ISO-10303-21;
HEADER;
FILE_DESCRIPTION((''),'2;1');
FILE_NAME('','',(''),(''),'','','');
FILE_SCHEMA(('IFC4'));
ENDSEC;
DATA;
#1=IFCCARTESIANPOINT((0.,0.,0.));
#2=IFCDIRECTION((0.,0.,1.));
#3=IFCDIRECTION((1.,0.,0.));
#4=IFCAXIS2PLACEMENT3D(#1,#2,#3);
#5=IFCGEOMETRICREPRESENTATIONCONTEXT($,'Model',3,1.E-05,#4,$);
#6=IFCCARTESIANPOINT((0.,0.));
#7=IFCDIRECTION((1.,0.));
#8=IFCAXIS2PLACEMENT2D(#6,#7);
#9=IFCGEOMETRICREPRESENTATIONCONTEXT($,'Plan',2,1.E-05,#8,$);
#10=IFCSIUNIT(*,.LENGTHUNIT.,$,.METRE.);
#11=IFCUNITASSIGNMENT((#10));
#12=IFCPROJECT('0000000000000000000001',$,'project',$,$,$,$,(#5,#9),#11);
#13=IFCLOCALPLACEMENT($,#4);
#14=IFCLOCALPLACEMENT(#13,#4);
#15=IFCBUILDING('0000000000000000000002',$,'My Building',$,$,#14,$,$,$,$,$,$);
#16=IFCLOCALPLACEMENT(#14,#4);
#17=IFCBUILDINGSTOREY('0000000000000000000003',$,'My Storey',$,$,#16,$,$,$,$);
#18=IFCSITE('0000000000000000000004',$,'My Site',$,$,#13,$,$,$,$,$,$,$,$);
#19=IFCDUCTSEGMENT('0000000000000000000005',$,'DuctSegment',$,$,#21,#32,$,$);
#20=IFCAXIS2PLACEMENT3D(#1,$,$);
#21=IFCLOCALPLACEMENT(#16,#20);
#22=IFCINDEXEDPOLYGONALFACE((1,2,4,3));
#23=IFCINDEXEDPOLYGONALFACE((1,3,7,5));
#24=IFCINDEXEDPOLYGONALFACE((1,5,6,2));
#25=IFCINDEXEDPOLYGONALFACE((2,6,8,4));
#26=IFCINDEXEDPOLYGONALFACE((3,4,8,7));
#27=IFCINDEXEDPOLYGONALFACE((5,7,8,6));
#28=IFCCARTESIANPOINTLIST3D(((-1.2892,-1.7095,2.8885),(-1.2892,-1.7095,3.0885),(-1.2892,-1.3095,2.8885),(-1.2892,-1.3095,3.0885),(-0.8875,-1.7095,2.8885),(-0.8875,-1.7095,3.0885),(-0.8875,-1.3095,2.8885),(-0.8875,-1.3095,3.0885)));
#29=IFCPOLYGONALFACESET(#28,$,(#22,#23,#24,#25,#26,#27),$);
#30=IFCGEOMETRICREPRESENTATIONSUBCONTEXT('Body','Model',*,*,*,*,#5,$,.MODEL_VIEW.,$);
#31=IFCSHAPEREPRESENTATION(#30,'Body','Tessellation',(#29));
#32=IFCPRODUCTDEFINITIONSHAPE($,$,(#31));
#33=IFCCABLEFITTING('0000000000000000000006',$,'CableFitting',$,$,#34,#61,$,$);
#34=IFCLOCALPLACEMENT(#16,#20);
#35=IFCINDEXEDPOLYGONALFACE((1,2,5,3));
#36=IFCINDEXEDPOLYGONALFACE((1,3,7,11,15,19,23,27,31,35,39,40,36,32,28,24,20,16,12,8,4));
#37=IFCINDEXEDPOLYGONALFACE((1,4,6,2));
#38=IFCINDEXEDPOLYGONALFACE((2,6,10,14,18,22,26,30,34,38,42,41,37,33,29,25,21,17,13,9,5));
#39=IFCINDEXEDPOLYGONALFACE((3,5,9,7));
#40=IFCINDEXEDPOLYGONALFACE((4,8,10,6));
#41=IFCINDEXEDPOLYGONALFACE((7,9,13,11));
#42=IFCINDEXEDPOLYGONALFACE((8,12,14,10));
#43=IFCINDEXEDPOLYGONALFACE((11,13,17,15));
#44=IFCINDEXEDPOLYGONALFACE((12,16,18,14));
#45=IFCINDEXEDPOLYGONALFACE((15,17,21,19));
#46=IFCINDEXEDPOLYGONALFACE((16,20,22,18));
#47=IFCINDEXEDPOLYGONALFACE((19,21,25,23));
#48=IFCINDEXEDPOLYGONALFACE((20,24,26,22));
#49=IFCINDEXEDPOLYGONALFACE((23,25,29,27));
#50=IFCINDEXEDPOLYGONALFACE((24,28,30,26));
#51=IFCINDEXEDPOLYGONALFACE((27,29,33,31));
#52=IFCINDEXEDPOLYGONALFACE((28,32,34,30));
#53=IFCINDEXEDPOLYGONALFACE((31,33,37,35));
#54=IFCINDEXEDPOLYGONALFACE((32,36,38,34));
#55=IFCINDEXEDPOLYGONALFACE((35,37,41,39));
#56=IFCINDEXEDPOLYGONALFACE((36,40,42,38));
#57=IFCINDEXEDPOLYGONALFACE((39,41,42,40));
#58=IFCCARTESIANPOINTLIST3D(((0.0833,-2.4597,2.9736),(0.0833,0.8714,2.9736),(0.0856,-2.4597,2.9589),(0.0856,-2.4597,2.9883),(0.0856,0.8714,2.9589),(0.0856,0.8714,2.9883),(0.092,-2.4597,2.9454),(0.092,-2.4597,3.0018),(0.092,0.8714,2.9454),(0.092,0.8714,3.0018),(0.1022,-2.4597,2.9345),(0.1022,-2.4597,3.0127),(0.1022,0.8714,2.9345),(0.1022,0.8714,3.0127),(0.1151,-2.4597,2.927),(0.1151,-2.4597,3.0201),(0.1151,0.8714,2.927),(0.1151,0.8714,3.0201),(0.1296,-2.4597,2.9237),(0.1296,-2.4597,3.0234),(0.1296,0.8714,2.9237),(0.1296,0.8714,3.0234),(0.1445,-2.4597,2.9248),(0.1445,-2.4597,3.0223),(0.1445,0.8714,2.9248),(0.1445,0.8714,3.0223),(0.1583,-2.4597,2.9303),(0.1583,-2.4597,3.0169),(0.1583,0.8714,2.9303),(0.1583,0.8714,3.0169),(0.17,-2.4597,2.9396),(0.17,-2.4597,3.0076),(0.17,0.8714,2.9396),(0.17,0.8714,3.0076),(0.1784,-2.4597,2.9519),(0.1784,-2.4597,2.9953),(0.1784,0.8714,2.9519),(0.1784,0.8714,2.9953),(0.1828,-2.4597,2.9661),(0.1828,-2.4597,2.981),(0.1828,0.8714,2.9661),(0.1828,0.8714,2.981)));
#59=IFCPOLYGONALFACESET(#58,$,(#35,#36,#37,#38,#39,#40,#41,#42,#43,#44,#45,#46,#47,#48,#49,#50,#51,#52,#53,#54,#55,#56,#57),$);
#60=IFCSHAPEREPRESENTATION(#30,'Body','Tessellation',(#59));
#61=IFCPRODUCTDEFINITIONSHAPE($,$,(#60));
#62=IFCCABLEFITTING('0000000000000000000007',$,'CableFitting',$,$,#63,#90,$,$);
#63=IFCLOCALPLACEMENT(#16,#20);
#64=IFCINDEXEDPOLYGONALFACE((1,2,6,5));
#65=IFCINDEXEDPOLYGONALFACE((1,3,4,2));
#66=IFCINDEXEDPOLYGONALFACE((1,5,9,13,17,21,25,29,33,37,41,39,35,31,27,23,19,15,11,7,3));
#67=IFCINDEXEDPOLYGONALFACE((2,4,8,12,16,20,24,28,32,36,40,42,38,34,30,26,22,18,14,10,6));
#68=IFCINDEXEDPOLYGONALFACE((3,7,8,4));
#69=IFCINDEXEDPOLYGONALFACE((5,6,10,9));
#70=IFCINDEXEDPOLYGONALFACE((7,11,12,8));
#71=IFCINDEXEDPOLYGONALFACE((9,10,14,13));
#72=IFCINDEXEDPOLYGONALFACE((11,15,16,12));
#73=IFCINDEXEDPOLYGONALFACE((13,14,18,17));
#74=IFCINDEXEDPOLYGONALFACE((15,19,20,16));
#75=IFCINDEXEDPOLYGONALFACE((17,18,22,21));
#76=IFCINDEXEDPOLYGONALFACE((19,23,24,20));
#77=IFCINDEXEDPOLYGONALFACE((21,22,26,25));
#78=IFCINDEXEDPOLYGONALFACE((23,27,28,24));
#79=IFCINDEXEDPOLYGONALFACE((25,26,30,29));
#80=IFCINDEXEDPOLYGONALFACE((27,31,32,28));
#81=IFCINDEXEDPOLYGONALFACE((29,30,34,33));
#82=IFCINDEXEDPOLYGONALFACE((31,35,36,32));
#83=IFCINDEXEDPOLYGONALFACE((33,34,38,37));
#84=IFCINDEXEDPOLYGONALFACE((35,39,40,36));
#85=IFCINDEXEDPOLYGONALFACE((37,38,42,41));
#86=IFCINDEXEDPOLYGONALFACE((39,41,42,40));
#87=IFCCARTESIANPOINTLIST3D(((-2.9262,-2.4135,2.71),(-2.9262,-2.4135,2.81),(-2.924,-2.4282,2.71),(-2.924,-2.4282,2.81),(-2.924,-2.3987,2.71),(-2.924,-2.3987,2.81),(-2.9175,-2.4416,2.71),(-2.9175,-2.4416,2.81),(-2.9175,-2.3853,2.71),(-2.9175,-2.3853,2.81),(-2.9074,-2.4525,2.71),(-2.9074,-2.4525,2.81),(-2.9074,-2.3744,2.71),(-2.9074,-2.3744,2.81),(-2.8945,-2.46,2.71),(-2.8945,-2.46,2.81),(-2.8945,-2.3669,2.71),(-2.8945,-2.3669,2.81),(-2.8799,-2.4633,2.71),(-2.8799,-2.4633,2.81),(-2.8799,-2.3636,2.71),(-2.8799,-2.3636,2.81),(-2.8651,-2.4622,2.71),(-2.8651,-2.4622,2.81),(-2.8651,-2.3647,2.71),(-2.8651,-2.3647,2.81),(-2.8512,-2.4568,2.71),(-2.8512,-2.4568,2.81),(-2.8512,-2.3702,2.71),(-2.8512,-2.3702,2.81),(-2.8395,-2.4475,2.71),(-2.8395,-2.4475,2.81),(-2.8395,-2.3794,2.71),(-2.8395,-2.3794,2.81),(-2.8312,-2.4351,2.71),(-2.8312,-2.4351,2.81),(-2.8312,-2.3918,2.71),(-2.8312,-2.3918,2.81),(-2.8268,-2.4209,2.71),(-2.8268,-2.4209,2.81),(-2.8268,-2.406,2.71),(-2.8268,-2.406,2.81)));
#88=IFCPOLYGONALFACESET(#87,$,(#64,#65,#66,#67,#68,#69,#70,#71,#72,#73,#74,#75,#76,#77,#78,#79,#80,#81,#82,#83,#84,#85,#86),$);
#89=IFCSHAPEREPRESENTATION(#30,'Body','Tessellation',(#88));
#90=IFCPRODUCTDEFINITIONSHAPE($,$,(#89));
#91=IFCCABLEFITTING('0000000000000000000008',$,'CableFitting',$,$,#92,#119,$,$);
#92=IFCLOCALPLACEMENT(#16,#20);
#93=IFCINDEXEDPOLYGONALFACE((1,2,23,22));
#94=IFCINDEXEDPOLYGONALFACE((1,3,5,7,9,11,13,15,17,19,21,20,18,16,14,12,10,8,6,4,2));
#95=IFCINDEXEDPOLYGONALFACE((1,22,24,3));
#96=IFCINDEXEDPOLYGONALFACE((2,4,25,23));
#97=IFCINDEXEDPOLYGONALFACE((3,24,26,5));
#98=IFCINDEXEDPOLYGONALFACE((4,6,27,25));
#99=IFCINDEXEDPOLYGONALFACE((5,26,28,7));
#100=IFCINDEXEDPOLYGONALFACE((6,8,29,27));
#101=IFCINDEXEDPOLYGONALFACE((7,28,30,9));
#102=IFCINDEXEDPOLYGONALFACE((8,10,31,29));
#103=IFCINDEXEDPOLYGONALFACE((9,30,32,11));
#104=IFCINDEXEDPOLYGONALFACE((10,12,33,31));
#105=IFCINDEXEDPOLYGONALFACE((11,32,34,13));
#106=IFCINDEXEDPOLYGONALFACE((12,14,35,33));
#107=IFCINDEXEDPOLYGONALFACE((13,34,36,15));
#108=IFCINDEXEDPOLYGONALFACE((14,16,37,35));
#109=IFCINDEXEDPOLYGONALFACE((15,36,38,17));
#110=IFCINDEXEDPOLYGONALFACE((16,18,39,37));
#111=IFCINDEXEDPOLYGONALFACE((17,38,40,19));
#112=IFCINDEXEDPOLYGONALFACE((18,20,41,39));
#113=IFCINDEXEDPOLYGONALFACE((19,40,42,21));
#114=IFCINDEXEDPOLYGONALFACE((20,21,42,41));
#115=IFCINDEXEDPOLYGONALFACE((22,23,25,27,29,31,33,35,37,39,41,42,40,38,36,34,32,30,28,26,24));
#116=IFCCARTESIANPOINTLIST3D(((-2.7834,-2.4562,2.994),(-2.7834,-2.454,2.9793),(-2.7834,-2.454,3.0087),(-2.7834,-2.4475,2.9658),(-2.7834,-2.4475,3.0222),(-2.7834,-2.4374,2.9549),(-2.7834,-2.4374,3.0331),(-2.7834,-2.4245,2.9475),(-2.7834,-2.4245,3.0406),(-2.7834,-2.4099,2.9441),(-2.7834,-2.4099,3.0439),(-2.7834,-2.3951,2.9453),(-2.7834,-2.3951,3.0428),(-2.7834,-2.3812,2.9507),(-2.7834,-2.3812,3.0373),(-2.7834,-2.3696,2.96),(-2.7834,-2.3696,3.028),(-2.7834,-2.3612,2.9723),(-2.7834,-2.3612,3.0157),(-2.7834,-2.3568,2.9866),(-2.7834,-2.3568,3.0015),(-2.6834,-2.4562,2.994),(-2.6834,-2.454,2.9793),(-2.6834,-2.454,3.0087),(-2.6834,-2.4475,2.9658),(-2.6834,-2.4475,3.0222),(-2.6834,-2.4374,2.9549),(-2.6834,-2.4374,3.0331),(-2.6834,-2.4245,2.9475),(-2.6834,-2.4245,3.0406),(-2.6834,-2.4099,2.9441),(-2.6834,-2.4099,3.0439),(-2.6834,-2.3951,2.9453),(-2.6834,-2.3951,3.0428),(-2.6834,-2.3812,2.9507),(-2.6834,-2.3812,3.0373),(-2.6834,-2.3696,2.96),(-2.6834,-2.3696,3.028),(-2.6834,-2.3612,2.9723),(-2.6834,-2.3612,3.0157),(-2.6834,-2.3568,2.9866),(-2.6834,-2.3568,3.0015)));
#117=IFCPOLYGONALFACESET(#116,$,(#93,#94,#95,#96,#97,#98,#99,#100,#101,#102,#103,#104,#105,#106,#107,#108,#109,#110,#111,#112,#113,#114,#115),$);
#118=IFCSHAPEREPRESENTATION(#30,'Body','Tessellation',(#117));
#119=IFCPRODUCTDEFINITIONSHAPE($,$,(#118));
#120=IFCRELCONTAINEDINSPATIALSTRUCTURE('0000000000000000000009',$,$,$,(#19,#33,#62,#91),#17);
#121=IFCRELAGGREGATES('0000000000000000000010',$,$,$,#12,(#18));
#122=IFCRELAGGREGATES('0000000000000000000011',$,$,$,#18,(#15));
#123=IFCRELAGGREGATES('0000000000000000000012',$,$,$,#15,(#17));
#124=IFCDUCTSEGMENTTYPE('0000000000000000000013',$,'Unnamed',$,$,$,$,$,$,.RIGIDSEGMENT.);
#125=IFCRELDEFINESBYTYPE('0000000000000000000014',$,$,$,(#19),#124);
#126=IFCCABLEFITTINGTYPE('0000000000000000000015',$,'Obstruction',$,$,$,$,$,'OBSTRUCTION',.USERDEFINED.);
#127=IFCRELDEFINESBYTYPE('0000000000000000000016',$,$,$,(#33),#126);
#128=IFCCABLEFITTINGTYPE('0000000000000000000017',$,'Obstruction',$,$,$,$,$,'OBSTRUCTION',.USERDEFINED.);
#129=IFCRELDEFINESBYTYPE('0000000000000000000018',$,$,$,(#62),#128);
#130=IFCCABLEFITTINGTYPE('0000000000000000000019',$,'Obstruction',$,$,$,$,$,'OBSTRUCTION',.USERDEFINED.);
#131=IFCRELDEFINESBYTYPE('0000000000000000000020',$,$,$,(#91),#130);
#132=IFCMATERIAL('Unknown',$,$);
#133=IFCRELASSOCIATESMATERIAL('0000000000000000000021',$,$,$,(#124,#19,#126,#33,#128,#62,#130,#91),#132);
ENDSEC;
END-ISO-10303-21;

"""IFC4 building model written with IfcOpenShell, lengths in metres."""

from ifc_helpers import new_model, si_unit, frame, origin_with_axes, origin_2d_with_axis, place, context, subcontext, project, spatial, rectangle, circle, extrude, material, material_profile, profile_set, profile_usage, type_object, element, save


model = new_model("IFC4")

# Units and contexts
model_context = context("Model", 3, precision=1e-05, world=origin_with_axes())
plan_context = context("Plan", 2, precision=1e-05, world=origin_2d_with_axis())
body_context_1 = subcontext(model_context, "Body", "Model", "MODEL_VIEW")
ifc_project = project(units=[si_unit("LENGTHUNIT", "METRE")], contexts=[model_context, plan_context])

# Site, building, storey
site_placement = place(None, origin_with_axes())
site = spatial("IfcSite", under=ifc_project, at=site_placement, Name="My Site")
building_placement = place(site_placement, origin_with_axes())
building = spatial("IfcBuilding", under=site, at=building_placement, Name="My Building")
storey_placement = place(building_placement, origin_with_axes())
storey = spatial("IfcBuildingStorey", under=building, at=storey_placement, Name="My Storey")

# Shared definitions
ifc_material = material(Name="Unknown")

# Duct segment
ifc_material_profile_1 = material_profile(ifc_material, rectangle(XDim=0.4, YDim=0.2))
ifc_profile_set_1 = profile_set([ifc_material_profile_1])
duct_segment_type_1 = type_object("IfcDuctSegmentType", Name="Unnamed", PredefinedType="RIGIDSEGMENT", material=ifc_profile_set_1)
ifc_profile_usage_1 = profile_usage(ifc_profile_set_1, cardinal=5)
duct_segment_1_placement = place(storey_placement, frame((-0.8875, -1.5095, 2.9885), z_axis=(-1.0, 0.0, 0.0), x_axis=(0.0, -1.0, 0.0)))
element("IfcDuctSegment", 1, at=duct_segment_1_placement, inside=storey, type_object=duct_segment_type_1, material=ifc_profile_usage_1, Name="DuctSegment", context=body_context_1, shape_type="SweptSolid", body=[
    extrude(rectangle(XDim=0.4, YDim=0.2), origin_with_axes(), (0.0, 0.0, 1.0), 0.4017),
])

# Cable fittings
ifc_material_profile_2 = material_profile(ifc_material, circle(Radius=0.05))
ifc_profile_set_2 = profile_set([ifc_material_profile_2])
ifc_profile_usage_2 = profile_usage(ifc_profile_set_2, cardinal=5)
cable_fitting_type_1 = type_object("IfcCableFittingType", Name="Obstruction", ElementType="OBSTRUCTION", PredefinedType="USERDEFINED", material=ifc_profile_set_2)
cable_fitting_1_placement = place(storey_placement, frame((0.1333, -2.4597, 2.9736), z_axis=(0.0, 1.0, 0.0), x_axis=(-1.0, 0.0, 0.0)))
element("IfcCableFitting", 2, at=cable_fitting_1_placement, inside=storey, type_object=cable_fitting_type_1, material=ifc_profile_usage_2, Name="CableFitting", context=body_context_1, shape_type="SweptSolid", body=[
    extrude(circle(Radius=0.05), origin_with_axes(), (0.0, 0.0, 1.0), 3.3311),
])
ifc_material_profile_3 = material_profile(ifc_material, circle(Radius=0.05))
ifc_profile_set_3 = profile_set([ifc_material_profile_3])
ifc_profile_usage_3 = profile_usage(ifc_profile_set_3, cardinal=5)
cable_fitting_type_2 = type_object("IfcCableFittingType", Name="Obstruction", ElementType="OBSTRUCTION", PredefinedType="USERDEFINED", material=ifc_profile_set_3)
cable_fitting_2_placement = place(storey_placement, frame((-2.8762, -2.4135, 2.81), z_axis=(0.0, 0.0, -1.0), x_axis=(-1.0, 0.0, 0.0)))
element("IfcCableFitting", 3, at=cable_fitting_2_placement, inside=storey, type_object=cable_fitting_type_2, material=ifc_profile_usage_3, Name="CableFitting", context=body_context_1, shape_type="SweptSolid", body=[
    extrude(circle(Radius=0.05), origin_with_axes(), (0.0, 0.0, 1.0), 0.1),
])
ifc_material_profile_4 = material_profile(ifc_material, circle(Radius=0.05))
ifc_profile_set_4 = profile_set([ifc_material_profile_4])
ifc_profile_usage_4 = profile_usage(ifc_profile_set_4, cardinal=5)
cable_fitting_type_3 = type_object("IfcCableFittingType", Name="Obstruction", ElementType="OBSTRUCTION", PredefinedType="USERDEFINED", material=ifc_profile_set_4)
cable_fitting_3_placement = place(storey_placement, frame((-2.6834, -2.4062, 2.994), z_axis=(-1.0, 0.0, 0.0), x_axis=(0.0, -1.0, 0.0)))
element("IfcCableFitting", 4, at=cable_fitting_3_placement, inside=storey, type_object=cable_fitting_type_3, material=ifc_profile_usage_4, Name="CableFitting", context=body_context_1, shape_type="SweptSolid", body=[
    extrude(circle(Radius=0.05), origin_with_axes(), (0.0, 0.0, 1.0), 0.1),
])

save(model, "model.ifc")
